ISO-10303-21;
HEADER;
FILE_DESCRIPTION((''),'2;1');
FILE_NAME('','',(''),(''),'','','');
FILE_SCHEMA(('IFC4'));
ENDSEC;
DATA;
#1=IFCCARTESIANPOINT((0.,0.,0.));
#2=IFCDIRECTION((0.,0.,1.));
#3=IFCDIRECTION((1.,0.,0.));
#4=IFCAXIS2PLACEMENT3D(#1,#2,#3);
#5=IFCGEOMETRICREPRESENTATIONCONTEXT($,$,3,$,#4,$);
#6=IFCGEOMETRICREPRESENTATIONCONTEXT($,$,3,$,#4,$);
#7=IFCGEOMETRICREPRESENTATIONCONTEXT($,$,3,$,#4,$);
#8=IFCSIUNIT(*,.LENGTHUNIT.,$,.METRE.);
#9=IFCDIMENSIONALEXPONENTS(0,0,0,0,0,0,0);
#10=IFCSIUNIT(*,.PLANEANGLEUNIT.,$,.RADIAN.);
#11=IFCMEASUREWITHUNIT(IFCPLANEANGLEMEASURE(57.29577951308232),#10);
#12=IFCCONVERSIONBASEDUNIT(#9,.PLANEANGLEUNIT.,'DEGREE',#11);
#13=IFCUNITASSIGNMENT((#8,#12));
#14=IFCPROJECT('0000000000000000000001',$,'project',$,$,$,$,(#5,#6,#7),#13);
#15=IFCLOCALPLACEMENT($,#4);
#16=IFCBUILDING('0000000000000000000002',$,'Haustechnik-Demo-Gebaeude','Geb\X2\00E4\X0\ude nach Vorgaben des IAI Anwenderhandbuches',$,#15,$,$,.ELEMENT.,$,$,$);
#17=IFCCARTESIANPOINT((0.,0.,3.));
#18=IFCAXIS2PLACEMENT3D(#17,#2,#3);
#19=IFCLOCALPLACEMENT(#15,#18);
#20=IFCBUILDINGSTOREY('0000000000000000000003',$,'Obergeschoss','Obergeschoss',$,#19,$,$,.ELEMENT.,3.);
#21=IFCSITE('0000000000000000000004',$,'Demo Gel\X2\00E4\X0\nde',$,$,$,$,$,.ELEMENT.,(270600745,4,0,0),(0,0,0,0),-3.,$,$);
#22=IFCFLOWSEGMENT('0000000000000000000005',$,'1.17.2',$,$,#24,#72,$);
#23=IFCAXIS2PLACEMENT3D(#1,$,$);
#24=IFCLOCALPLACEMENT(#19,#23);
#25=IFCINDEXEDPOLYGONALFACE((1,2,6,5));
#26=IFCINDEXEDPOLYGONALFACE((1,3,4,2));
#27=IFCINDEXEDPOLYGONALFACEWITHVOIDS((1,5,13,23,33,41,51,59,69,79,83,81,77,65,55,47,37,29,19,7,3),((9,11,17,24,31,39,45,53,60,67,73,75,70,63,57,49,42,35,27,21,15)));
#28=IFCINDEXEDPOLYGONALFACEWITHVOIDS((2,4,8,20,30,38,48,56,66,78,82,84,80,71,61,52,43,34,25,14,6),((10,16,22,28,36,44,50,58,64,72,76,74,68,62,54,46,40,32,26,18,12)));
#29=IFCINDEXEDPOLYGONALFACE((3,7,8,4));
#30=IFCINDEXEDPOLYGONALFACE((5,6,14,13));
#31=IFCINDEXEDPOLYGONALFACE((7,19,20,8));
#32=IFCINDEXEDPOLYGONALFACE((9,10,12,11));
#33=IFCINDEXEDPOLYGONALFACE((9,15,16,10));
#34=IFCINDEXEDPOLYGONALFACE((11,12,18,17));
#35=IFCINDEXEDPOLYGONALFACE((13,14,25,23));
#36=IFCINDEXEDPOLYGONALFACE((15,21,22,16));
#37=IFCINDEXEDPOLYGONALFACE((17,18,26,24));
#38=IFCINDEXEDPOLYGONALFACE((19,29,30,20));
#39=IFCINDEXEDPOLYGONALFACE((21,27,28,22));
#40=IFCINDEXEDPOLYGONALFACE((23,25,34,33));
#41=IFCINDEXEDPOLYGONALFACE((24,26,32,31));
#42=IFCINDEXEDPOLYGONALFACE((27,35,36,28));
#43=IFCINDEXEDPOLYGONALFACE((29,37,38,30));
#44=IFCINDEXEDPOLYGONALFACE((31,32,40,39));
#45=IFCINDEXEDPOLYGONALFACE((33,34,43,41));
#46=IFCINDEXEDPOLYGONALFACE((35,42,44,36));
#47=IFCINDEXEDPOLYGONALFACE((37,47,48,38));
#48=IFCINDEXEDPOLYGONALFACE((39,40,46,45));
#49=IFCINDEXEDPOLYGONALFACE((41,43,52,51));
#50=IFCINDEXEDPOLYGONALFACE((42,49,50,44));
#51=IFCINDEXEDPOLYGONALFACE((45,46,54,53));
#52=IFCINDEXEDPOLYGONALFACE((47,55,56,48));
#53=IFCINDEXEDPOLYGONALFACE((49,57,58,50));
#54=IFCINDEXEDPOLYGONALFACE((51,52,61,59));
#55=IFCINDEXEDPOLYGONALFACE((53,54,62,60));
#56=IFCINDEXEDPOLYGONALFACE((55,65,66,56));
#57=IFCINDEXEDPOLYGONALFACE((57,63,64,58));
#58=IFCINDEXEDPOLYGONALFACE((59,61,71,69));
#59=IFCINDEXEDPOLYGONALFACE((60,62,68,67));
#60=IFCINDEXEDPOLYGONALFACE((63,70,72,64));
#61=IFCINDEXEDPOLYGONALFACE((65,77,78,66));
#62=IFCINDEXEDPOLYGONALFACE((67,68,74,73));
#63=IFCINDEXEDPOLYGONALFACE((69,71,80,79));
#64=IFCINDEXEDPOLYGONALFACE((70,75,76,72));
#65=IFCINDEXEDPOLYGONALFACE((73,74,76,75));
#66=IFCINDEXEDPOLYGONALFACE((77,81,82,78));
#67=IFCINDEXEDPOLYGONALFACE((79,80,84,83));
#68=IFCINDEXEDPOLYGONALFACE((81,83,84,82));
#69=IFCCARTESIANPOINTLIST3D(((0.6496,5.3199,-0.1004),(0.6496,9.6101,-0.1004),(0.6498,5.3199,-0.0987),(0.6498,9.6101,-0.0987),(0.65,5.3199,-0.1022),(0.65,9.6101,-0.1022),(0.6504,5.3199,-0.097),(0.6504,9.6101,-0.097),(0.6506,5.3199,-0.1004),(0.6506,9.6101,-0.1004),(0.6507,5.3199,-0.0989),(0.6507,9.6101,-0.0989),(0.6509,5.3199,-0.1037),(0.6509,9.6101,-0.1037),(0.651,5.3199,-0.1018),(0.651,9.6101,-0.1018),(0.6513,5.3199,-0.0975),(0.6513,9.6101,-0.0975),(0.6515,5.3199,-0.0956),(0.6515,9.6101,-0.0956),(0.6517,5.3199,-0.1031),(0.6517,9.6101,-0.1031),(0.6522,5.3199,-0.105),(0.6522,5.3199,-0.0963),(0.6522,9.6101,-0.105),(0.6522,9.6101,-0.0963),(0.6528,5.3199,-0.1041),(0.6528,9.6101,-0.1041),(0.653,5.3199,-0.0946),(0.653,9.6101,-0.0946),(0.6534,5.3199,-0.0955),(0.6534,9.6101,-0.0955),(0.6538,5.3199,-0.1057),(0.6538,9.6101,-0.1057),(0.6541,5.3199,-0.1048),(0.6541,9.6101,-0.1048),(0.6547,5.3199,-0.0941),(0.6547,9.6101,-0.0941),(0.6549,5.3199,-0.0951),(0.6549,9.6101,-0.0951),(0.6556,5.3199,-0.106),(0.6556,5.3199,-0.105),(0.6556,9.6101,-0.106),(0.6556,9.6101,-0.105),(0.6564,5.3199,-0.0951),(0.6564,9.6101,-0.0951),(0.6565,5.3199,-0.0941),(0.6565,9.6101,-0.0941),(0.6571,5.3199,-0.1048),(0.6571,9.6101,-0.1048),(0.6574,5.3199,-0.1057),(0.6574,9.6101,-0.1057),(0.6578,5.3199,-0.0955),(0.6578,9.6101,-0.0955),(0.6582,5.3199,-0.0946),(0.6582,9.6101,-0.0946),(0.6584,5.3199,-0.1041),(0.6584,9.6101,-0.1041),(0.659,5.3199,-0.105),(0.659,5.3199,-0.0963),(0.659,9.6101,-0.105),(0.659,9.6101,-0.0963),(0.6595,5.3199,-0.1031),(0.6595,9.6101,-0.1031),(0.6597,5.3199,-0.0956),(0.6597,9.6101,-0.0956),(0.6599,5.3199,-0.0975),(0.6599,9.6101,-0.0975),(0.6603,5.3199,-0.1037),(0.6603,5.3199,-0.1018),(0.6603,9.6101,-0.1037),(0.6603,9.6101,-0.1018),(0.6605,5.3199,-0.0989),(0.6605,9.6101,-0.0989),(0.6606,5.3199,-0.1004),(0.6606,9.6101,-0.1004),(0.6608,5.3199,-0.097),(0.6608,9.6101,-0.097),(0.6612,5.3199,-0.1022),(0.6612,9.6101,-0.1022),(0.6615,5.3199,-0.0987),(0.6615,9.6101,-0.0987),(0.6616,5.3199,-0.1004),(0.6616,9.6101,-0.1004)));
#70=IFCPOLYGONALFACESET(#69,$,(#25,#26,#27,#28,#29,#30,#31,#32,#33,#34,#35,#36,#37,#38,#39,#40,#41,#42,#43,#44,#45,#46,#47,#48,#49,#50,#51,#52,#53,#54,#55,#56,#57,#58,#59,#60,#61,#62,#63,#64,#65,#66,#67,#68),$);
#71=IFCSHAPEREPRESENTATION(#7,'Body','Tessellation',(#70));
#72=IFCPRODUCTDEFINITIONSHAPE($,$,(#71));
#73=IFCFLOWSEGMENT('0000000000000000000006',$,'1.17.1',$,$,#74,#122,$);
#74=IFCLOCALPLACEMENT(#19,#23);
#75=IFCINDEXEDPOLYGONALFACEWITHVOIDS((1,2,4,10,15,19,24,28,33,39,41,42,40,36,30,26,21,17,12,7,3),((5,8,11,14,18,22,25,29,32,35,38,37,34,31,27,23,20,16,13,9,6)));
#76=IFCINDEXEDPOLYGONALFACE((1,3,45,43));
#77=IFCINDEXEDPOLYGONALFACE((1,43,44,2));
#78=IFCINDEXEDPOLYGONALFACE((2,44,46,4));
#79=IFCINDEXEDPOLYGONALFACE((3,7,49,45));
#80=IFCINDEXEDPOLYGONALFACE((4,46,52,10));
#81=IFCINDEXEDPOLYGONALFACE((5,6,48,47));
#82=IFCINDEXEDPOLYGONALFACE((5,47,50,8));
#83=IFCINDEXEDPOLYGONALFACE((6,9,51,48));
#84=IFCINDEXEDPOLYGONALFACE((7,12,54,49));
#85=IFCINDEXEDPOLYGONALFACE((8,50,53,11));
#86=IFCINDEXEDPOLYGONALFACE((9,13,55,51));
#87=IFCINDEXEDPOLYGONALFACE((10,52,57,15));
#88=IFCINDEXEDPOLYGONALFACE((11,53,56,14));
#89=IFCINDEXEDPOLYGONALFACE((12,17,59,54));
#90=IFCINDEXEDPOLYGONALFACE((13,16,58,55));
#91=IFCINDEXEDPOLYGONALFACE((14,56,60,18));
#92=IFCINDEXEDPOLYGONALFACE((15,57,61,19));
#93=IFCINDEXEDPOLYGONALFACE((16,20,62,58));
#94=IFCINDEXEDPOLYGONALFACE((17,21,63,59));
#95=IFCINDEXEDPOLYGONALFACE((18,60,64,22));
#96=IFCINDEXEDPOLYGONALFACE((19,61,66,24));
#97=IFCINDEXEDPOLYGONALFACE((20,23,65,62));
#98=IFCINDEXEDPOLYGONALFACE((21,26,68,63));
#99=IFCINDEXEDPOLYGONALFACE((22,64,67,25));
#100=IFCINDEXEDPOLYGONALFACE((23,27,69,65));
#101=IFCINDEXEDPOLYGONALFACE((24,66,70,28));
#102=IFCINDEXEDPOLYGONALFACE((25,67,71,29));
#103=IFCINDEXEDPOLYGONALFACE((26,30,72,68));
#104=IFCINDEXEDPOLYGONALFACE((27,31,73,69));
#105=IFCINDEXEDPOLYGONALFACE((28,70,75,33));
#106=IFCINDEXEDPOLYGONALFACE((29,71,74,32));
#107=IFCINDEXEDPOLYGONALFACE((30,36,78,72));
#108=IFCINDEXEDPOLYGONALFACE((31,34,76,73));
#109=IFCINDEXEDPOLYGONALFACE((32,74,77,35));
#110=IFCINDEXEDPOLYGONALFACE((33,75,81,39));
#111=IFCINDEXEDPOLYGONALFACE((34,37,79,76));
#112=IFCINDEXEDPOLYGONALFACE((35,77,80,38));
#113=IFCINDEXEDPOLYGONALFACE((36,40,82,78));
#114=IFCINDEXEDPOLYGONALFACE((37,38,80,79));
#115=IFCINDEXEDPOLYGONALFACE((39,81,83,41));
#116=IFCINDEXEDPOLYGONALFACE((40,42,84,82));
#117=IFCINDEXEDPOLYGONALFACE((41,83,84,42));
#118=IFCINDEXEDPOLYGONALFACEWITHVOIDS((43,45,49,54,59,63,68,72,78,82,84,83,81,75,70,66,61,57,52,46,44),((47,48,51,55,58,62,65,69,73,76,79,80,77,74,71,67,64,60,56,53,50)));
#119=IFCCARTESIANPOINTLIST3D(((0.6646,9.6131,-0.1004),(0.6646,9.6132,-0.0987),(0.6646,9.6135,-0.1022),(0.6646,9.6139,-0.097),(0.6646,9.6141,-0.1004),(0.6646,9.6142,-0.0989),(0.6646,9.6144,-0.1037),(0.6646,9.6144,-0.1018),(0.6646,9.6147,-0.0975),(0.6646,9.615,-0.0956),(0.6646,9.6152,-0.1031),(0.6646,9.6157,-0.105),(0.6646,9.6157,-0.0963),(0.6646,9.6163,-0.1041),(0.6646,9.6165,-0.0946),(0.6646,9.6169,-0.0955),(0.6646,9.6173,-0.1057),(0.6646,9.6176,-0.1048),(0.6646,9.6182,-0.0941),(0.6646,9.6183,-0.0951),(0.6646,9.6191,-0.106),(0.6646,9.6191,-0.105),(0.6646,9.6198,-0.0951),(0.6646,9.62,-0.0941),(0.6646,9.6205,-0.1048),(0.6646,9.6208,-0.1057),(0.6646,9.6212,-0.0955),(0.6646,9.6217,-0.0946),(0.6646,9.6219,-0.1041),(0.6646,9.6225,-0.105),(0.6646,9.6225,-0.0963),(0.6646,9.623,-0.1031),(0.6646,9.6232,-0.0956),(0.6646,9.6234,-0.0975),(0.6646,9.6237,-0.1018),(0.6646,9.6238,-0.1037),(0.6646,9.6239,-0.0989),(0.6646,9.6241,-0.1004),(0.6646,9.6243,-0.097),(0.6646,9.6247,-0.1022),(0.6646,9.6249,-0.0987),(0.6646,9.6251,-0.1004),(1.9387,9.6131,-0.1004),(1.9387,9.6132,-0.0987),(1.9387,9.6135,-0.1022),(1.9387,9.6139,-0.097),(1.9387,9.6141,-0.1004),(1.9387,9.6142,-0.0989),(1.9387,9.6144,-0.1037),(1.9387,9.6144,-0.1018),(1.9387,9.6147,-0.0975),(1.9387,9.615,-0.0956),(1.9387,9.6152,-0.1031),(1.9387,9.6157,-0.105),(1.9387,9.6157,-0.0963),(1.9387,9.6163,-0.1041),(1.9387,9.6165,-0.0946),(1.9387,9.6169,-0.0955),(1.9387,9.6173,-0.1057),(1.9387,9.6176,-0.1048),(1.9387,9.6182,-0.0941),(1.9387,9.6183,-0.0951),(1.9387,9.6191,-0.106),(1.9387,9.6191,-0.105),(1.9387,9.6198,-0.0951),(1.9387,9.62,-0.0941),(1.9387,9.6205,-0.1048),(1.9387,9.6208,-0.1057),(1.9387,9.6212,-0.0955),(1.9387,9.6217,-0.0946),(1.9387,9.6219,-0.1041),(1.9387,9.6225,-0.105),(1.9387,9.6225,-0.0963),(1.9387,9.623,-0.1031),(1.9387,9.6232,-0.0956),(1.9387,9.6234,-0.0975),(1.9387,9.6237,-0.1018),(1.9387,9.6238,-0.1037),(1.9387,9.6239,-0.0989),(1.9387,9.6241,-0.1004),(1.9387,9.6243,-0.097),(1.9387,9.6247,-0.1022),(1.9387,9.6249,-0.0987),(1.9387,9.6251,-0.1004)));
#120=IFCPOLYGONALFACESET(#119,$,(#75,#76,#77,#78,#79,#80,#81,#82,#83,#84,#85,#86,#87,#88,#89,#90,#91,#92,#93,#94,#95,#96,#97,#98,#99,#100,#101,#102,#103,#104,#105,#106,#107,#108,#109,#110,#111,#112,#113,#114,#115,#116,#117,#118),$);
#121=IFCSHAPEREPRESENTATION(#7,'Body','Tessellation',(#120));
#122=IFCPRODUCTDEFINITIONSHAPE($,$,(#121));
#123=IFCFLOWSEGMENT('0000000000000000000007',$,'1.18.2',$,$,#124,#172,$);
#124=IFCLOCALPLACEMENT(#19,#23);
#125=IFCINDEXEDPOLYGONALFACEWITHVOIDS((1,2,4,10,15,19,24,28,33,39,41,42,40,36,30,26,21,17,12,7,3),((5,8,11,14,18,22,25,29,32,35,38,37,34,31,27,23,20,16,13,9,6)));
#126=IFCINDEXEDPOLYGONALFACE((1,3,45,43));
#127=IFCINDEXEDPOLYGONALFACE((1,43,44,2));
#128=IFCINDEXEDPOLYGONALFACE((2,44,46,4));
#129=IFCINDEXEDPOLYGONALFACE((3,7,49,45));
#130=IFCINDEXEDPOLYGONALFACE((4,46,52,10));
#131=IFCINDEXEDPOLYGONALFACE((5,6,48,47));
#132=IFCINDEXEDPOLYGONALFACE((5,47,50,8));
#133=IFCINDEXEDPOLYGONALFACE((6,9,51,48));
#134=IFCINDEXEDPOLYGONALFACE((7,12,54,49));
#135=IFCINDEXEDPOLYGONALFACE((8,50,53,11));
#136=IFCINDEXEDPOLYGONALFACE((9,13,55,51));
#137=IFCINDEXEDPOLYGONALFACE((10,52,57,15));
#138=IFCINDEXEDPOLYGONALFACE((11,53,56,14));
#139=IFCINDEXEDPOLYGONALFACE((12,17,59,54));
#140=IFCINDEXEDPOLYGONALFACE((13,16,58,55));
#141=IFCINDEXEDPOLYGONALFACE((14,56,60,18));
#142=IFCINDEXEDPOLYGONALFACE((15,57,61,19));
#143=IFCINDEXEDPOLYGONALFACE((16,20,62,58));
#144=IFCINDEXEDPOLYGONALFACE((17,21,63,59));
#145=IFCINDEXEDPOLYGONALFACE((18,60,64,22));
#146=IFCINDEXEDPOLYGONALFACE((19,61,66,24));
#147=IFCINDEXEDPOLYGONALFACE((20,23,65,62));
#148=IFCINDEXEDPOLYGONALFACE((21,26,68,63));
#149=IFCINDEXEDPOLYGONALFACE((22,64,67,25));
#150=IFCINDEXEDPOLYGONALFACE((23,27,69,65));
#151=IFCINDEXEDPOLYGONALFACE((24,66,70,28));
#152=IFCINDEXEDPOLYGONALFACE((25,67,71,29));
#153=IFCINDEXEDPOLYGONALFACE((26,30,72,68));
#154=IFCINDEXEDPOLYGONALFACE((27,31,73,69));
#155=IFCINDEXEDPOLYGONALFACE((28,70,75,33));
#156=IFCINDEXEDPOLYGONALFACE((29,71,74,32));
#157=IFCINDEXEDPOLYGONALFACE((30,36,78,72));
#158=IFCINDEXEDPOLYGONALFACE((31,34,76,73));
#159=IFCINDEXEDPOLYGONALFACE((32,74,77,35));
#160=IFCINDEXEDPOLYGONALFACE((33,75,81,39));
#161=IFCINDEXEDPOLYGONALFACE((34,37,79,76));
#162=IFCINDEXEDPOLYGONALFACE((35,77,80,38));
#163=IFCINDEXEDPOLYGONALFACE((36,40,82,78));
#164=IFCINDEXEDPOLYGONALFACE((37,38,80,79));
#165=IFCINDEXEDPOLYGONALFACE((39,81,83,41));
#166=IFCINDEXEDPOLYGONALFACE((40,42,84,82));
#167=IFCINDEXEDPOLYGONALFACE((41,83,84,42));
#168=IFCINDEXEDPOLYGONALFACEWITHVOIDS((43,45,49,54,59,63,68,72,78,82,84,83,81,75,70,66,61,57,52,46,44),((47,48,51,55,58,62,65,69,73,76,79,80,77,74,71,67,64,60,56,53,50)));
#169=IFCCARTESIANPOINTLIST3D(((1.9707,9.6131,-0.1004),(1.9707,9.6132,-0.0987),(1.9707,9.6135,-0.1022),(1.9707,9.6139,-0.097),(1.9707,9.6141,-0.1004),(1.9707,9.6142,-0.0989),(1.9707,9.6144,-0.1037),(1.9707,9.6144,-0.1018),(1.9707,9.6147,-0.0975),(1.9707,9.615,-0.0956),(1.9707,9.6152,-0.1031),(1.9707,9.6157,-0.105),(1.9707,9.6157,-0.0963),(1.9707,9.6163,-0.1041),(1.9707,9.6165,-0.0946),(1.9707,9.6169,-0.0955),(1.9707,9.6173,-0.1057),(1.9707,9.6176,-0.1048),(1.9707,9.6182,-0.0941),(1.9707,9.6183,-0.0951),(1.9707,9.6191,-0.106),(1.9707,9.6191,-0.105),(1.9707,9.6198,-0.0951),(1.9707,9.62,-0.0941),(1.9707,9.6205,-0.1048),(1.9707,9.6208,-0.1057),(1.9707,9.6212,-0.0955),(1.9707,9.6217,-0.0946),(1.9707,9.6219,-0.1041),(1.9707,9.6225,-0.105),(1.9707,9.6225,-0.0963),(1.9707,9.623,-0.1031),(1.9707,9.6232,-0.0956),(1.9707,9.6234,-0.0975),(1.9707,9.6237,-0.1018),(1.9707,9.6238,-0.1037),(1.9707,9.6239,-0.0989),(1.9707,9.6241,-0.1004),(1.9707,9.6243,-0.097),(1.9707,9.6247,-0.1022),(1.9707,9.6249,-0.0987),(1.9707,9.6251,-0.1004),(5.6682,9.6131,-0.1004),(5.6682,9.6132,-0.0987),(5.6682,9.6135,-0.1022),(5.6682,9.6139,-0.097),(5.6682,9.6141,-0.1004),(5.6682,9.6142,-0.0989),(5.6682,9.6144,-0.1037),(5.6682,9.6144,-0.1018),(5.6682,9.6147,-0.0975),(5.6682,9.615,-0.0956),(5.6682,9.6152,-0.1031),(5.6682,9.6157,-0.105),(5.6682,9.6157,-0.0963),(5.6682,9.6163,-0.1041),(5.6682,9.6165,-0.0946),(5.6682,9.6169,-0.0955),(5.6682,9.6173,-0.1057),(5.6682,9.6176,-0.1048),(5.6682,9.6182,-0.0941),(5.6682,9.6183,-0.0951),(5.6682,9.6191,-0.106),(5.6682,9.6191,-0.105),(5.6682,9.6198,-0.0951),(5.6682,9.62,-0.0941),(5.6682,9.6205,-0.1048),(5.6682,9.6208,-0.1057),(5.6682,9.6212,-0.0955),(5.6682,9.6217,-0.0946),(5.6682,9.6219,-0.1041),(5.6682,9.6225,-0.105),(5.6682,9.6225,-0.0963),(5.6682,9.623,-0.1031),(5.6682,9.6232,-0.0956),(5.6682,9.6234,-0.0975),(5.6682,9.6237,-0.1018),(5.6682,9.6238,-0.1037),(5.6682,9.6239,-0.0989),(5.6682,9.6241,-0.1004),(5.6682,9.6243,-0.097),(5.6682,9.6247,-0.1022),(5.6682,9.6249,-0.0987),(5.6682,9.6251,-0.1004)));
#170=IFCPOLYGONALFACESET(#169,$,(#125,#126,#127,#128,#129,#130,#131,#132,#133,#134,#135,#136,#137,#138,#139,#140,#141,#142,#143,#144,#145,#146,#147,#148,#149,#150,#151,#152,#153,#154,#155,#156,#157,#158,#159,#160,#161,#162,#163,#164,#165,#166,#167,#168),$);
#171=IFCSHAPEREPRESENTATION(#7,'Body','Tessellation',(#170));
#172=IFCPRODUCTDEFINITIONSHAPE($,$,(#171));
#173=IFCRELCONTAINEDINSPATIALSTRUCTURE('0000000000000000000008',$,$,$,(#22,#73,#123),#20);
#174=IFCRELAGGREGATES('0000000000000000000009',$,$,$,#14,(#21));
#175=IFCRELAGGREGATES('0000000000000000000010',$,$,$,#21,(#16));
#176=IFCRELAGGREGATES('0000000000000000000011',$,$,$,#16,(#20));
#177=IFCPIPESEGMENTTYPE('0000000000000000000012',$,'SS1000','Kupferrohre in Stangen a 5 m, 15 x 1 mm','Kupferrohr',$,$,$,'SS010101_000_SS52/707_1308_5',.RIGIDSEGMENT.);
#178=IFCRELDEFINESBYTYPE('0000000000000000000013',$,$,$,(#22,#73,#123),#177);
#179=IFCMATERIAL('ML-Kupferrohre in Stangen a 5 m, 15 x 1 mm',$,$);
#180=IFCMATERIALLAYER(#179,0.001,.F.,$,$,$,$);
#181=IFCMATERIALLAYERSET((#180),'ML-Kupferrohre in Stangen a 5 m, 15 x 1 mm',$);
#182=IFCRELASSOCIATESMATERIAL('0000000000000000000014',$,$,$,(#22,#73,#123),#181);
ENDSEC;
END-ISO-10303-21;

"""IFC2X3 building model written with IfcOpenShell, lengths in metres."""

from ifc_helpers import new_model, entity, si_unit, converted_unit, frame, origin_with_axes, origin_2d_with_axis, place, context, project, spatial, hollow_circle, extrude, material, layer, layer_set, layer_usage, type_object, element, save


model = new_model("IFC2X3")

# Units and contexts
context_of_model_1 = context(None, 3, world=origin_with_axes())
context_of_model_2 = context(None, 3, world=origin_with_axes())
context_of_model_3 = context(None, 3, world=origin_with_axes())
ifc_project = project(units=[si_unit("LENGTHUNIT", "METRE"), converted_unit("PLANEANGLEUNIT", "DEGREE", entity("IfcPlaneAngleMeasure", 57.29577951308232), si_unit("PLANEANGLEUNIT", "RADIAN"), dimensions=[0, 0, 0, 0, 0, 0, 0])], contexts=[context_of_model_1, context_of_model_2, context_of_model_3])

# Site, building, storey
site = spatial("IfcSite", under=ifc_project, Name="Demo Gelände", CompositionType="ELEMENT", RefLatitude=(270600745, 4, 0, 0), RefLongitude=(0, 0, 0, 0), RefElevation=-3.0)
building_placement = place(None, origin_with_axes())
building = spatial("IfcBuilding", under=site, at=building_placement, Name="Haustechnik-Demo-Gebaeude", Description="Gebäude nach Vorgaben des IAI Anwenderhandbuches", CompositionType="ELEMENT")
storey_placement = place(building_placement, frame((0.0, 0.0, 3.0), z_axis=(0.0, 0.0, 1.0), x_axis=(1.0, 0.0, 0.0)))
storey = spatial("IfcBuildingStorey", under=building, at=storey_placement, Name="Obergeschoss", Description="Obergeschoss", CompositionType="ELEMENT", Elevation=3.0)

# Flow segments
ifc_material = material(Name="ML-Kupferrohre in Stangen a 5 m, 15 x 1 mm")
ifc_layer = layer(ifc_material, 0.001, ventilated=False)
ifc_layer_set = layer_set([ifc_layer], Name="ML-Kupferrohre in Stangen a 5 m, 15 x 1 mm")
ifc_layer_usage = layer_usage(ifc_layer_set, "AXIS2", "POSITIVE", 0.0)
pipe_segment_type_1 = type_object("IfcPipeSegmentType", Name="SS1000", Description="Kupferrohre in Stangen a 5 m, 15 x 1 mm", ApplicableOccurrence="Kupferrohr", ElementType="SS010101_000_SS52/707_1308_5", PredefinedType="RIGIDSEGMENT")
flow_segment_1_placement = place(storey_placement, frame((0.6556, 5.3199, -0.1), z_axis=(0.0, 1.0, 0.0), x_axis=(0.0, 0.0, -1.0)))
element("IfcFlowSegment", 1, at=flow_segment_1_placement, inside=storey, type_object=pipe_segment_type_1, material=ifc_layer_usage, Name="1.17.2", context=context_of_model_3, shape_type="SweptSolid", body=[
    extrude(hollow_circle(Radius=0.006, WallThickness=0.001, at=origin_2d_with_axis()), origin_with_axes(), (0.0, 0.0, 1.0), 4.2901),
])
flow_segment_2_placement = place(storey_placement, frame((0.6646, 9.6191, -0.1), z_axis=(1.0, 0.0, 0.0), x_axis=(0.0, 0.0, -1.0)))
element("IfcFlowSegment", 2, at=flow_segment_2_placement, inside=storey, type_object=pipe_segment_type_1, material=ifc_layer_usage, Name="1.17.1", context=context_of_model_3, shape_type="SweptSolid", body=[
    extrude(hollow_circle(Radius=0.006, WallThickness=0.001, at=origin_2d_with_axis()), origin_with_axes(), (0.0, 0.0, 1.0), 1.2741),
])
flow_segment_3_placement = place(storey_placement, frame((1.9707, 9.6191, -0.1), z_axis=(1.0, 0.0, 0.0), x_axis=(0.0, 0.0, -1.0)))
element("IfcFlowSegment", 3, at=flow_segment_3_placement, inside=storey, type_object=pipe_segment_type_1, material=ifc_layer_usage, Name="1.18.2", context=context_of_model_3, shape_type="SweptSolid", body=[
    extrude(hollow_circle(Radius=0.006, WallThickness=0.001, at=origin_2d_with_axis()), origin_with_axes(), (0.0, 0.0, 1.0), 3.6975),
])

save(model, "model.ifc")
